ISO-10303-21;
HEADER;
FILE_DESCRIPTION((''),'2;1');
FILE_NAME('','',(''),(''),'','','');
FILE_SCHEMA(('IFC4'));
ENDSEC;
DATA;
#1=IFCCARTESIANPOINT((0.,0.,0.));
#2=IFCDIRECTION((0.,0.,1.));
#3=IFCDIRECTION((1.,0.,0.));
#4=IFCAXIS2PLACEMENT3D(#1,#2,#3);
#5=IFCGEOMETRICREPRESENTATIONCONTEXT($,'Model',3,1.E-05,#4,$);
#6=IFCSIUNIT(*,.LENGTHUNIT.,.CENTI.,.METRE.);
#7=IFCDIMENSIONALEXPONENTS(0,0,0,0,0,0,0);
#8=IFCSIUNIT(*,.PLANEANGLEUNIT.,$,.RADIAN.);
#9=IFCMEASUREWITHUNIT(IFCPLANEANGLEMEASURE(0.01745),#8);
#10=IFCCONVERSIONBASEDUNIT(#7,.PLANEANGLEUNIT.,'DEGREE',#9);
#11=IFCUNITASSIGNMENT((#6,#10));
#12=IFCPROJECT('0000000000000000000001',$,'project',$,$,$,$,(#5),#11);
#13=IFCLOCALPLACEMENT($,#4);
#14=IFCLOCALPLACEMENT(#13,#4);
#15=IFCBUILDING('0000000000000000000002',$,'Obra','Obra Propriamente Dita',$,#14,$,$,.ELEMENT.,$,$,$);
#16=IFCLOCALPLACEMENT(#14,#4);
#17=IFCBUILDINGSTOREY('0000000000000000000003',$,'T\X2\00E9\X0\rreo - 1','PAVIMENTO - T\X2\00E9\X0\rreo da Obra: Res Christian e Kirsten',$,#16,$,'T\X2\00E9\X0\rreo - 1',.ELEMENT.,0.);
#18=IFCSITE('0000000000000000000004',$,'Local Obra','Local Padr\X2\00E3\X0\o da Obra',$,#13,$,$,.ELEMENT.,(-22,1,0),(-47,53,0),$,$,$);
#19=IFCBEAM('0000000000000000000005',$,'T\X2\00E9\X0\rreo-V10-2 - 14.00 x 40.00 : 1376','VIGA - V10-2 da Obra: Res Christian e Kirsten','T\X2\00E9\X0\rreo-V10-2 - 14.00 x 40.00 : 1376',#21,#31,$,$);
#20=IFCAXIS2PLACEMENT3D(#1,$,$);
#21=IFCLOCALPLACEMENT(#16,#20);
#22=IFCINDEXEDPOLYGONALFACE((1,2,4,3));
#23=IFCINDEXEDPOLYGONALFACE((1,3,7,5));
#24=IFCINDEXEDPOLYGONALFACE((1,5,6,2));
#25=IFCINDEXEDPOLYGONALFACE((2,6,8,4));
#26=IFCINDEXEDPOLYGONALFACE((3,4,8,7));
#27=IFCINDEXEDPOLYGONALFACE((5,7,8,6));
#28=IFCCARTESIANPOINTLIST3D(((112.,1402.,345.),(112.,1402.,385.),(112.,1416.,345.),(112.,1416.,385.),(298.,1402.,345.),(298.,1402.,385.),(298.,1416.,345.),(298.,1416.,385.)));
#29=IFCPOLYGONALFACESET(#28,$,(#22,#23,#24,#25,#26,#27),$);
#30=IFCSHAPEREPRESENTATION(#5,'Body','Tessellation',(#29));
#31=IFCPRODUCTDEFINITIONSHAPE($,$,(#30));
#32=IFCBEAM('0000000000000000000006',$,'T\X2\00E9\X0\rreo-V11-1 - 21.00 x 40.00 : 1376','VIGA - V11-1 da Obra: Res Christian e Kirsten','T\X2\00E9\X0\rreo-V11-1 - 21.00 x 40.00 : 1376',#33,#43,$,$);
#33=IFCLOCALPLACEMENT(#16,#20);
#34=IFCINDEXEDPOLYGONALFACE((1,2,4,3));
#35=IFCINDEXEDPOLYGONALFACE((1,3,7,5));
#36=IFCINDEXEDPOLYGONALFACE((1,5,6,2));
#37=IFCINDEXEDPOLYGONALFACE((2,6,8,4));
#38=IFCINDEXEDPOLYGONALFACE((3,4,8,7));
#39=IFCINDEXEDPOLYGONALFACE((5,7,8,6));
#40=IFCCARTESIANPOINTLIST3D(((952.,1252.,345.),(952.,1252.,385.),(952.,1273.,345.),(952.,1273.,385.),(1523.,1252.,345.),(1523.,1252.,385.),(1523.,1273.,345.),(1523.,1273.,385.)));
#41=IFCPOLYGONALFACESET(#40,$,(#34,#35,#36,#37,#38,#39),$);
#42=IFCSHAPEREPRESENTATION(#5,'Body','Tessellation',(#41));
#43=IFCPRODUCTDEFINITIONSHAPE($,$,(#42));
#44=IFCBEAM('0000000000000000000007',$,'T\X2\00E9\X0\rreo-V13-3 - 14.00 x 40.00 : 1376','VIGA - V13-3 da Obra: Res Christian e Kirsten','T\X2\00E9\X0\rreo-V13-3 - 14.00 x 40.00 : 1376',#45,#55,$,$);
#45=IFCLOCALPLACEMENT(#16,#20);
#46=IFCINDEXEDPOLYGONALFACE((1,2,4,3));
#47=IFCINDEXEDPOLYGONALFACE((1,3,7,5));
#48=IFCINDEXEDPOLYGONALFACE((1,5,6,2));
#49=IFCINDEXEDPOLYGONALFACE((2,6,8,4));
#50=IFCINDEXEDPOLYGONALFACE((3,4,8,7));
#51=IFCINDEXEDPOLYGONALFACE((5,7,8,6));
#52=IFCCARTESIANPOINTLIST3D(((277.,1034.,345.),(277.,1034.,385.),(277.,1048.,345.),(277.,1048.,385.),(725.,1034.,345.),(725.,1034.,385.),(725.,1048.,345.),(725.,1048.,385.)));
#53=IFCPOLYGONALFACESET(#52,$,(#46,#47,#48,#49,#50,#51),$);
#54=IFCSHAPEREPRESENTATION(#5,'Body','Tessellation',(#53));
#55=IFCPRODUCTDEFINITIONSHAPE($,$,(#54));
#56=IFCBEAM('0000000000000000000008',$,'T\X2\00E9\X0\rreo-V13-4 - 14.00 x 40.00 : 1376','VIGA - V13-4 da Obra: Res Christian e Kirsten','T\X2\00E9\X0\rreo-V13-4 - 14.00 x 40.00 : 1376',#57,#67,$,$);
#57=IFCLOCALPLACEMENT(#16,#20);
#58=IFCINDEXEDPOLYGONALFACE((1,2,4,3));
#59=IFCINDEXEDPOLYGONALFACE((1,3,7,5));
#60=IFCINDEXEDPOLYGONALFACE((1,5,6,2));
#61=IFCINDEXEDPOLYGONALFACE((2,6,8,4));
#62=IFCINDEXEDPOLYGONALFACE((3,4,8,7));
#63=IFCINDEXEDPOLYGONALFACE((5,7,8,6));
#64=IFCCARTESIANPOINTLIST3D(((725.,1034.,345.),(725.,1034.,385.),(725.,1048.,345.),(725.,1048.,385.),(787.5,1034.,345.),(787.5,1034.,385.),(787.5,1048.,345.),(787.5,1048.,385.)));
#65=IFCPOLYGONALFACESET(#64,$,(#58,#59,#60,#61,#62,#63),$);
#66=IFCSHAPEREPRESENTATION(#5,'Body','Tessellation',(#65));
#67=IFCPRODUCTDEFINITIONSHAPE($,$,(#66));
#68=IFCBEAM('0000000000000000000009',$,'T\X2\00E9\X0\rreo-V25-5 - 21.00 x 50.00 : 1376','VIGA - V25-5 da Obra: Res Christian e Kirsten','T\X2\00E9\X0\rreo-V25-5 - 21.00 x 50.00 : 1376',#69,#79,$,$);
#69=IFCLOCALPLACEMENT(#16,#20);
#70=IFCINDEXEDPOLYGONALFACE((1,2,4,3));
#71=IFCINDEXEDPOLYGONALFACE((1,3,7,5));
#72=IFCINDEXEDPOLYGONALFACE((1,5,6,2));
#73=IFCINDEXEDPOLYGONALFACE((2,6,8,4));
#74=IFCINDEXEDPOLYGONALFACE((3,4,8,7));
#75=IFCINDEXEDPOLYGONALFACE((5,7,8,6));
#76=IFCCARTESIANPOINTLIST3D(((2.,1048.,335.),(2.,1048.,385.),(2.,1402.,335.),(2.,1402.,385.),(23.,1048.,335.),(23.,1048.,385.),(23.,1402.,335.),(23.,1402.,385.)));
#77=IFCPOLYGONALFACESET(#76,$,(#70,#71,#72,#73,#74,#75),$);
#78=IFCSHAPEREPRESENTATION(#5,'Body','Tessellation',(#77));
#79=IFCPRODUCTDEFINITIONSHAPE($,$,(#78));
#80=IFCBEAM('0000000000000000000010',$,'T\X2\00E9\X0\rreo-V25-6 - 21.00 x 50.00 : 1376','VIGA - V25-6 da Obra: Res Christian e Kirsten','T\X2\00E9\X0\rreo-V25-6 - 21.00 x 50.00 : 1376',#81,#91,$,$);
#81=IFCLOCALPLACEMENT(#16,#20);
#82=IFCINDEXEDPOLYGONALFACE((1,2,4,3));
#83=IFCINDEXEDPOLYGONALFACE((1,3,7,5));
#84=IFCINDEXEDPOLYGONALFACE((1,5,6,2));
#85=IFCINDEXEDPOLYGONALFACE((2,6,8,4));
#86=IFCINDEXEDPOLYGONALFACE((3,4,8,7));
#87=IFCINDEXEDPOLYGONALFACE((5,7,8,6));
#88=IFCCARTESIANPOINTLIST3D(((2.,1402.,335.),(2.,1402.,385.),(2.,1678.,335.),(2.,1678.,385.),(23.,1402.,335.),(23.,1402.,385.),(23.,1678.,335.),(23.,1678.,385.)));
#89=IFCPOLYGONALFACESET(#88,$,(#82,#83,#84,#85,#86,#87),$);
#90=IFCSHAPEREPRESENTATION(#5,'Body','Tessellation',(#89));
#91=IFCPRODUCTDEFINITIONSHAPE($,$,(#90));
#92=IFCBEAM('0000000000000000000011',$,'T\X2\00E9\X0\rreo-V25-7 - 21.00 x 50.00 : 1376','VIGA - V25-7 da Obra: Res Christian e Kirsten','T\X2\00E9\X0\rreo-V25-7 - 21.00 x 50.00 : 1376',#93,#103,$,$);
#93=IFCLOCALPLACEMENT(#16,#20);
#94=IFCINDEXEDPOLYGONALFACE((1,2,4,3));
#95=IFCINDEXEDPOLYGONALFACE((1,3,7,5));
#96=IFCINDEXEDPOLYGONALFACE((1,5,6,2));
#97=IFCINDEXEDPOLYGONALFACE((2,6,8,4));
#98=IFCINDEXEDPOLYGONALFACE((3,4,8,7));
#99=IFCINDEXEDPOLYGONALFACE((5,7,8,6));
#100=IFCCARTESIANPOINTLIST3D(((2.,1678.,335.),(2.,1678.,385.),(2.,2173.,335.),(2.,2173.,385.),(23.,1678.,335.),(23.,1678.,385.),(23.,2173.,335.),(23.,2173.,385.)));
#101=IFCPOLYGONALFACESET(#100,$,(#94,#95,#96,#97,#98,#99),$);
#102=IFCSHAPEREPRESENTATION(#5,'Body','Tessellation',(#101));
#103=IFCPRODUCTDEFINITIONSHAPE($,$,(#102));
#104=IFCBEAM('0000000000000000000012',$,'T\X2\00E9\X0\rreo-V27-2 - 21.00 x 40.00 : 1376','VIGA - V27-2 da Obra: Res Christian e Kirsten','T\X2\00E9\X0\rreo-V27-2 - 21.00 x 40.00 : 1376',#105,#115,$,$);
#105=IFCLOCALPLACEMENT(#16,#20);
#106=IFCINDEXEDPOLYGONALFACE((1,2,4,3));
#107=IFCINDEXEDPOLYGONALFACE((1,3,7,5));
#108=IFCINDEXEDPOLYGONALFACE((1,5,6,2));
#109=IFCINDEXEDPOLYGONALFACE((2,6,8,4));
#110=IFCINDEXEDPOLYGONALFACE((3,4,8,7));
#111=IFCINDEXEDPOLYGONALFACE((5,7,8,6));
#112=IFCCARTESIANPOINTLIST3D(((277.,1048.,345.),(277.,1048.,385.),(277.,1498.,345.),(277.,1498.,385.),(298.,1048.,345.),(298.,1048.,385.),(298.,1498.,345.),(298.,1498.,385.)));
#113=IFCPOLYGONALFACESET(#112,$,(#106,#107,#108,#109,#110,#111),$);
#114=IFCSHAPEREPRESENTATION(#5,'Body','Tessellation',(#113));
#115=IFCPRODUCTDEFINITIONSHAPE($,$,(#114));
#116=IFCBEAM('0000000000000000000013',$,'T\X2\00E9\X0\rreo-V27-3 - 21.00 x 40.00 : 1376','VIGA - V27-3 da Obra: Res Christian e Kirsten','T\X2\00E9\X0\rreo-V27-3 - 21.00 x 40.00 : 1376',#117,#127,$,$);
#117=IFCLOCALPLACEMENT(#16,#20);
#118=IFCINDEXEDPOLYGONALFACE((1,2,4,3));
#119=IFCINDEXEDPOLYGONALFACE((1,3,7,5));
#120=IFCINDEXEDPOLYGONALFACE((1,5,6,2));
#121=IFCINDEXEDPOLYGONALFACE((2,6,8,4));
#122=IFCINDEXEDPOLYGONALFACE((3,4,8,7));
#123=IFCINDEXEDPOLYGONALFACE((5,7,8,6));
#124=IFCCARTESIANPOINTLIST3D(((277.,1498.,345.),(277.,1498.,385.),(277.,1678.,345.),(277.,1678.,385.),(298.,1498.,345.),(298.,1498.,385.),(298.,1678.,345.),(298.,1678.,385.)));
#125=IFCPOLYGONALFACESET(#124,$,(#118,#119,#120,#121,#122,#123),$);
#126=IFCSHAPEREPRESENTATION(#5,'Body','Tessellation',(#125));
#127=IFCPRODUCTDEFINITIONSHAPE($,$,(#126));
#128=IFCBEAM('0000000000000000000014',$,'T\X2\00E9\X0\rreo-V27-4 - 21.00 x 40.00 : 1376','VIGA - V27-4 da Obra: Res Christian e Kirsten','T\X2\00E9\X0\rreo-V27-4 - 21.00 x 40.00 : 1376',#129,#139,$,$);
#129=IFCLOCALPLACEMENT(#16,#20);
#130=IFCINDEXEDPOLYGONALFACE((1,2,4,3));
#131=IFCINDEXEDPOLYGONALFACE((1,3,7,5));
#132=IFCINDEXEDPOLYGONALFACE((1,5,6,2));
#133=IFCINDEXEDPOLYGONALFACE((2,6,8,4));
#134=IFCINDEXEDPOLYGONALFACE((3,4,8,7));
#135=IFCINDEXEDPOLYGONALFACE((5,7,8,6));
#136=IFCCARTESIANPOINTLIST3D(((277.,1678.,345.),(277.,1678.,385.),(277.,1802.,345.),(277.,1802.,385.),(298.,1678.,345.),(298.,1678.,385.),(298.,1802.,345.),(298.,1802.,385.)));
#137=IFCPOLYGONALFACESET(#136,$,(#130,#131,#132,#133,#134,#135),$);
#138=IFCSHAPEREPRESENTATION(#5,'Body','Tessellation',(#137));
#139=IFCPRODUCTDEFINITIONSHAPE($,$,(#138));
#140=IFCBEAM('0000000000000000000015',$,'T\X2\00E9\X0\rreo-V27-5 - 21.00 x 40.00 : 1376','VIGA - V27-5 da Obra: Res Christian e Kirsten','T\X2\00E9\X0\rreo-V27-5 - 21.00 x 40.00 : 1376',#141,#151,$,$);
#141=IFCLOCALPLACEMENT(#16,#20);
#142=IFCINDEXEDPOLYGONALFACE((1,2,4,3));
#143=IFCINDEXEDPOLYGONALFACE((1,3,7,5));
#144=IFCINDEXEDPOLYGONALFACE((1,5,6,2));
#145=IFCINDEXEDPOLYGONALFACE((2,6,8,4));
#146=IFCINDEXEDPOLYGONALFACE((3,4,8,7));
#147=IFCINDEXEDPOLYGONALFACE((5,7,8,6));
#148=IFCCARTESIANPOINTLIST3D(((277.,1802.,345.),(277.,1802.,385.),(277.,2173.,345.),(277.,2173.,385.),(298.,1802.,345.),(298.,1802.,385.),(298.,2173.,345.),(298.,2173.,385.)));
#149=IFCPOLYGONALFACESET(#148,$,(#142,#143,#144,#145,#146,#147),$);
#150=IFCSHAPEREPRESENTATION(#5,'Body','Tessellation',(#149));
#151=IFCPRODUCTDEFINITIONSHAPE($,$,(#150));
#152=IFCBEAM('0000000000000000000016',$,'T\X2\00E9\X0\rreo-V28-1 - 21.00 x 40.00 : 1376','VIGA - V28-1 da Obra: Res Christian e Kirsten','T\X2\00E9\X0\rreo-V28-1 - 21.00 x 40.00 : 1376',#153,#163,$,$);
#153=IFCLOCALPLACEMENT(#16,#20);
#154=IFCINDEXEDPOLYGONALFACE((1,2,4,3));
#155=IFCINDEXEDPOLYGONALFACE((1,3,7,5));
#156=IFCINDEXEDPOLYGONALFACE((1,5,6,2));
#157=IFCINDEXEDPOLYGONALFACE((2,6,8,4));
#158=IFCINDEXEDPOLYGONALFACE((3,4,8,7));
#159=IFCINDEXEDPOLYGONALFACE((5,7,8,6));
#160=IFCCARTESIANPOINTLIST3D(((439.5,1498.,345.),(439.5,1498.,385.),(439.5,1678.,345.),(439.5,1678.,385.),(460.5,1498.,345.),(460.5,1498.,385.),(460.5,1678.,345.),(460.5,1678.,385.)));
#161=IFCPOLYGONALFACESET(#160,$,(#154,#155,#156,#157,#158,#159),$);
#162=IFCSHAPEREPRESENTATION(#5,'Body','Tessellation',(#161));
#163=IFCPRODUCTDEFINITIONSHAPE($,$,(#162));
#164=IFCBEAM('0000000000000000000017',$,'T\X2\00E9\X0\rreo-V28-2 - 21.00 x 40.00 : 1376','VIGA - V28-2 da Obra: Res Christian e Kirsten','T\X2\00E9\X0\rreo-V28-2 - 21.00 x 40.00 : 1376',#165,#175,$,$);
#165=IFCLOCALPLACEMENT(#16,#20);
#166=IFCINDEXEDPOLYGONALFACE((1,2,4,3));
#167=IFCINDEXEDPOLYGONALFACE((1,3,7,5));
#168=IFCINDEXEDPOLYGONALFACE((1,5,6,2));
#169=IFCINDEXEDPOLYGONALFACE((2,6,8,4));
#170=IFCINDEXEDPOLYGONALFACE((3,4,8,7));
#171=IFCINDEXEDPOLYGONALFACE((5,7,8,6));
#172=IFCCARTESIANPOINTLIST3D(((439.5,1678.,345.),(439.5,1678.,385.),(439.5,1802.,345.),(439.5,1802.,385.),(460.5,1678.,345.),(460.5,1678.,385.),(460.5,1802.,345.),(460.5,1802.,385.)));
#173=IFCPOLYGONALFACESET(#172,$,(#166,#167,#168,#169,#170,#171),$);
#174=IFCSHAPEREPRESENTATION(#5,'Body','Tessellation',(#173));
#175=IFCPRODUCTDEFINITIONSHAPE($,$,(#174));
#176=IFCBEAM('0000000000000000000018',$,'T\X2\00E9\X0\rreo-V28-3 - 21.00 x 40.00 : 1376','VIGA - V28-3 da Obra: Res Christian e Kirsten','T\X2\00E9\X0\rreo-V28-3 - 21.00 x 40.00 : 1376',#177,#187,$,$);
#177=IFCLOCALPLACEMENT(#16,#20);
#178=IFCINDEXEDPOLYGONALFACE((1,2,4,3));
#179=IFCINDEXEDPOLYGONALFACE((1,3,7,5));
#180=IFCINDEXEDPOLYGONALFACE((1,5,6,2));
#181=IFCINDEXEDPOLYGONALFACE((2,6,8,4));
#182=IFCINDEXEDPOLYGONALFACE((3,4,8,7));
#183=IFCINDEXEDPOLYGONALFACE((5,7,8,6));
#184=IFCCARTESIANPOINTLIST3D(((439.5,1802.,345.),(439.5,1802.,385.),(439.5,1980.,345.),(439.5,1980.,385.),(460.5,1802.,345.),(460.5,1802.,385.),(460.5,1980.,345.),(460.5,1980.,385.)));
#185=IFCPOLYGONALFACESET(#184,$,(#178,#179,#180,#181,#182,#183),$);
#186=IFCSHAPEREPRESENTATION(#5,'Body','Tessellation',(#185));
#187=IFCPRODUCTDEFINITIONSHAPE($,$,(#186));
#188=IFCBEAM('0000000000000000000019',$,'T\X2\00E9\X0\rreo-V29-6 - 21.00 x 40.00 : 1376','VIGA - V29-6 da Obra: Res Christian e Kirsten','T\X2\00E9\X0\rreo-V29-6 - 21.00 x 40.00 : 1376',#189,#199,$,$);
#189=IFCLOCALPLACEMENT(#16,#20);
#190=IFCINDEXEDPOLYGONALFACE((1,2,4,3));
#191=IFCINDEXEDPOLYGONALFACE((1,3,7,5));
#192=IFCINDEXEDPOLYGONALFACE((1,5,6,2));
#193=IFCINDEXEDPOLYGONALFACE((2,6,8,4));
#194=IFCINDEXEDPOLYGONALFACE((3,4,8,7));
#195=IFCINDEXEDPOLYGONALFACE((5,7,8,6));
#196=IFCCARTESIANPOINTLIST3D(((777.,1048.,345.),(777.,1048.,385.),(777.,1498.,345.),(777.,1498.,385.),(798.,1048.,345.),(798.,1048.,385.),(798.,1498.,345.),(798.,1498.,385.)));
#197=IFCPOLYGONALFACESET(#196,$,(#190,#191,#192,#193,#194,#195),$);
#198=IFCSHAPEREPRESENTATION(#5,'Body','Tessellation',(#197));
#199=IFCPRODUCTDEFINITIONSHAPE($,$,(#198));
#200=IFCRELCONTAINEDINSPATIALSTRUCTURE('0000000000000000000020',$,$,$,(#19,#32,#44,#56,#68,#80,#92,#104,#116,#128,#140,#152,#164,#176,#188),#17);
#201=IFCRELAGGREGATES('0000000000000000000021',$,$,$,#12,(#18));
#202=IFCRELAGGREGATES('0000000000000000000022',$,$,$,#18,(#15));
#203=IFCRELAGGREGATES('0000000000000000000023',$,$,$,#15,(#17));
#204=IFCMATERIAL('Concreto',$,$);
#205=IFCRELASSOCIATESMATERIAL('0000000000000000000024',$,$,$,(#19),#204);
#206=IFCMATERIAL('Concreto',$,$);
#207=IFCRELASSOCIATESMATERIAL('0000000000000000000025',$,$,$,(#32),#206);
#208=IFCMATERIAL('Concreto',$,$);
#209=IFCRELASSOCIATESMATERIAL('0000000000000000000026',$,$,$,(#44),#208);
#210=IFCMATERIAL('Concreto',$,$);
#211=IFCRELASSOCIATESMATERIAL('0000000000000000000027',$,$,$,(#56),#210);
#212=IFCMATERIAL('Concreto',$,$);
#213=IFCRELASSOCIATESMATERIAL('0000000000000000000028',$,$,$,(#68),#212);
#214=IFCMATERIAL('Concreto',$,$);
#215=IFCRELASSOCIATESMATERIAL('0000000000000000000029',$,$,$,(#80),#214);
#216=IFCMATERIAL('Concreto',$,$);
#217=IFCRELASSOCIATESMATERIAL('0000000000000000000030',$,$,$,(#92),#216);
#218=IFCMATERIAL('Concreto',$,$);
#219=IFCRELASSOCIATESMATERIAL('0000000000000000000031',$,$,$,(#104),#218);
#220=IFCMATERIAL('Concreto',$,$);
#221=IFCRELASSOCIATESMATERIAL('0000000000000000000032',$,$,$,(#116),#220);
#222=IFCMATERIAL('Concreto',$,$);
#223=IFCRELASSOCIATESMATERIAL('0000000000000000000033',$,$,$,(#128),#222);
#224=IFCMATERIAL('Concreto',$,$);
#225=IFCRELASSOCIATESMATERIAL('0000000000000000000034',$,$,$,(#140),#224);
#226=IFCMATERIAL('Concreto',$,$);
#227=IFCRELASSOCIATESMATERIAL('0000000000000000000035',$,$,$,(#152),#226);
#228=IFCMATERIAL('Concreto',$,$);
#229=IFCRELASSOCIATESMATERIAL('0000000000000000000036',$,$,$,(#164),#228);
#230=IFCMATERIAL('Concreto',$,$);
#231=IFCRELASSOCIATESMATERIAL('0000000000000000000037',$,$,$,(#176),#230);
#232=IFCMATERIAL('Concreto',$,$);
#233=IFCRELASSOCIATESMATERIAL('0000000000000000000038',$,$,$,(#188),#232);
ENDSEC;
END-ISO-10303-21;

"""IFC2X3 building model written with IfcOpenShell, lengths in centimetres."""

from ifc_helpers import new_model, entity, si_unit, converted_unit, frame, origin_with_axes, place, context, project, spatial, polyline, outline, extrude, material, element, save


model = new_model("IFC2X3")

# Units and contexts
model_context = context("Model", 3, precision=1e-05, world=origin_with_axes())
ifc_project = project(units=[si_unit("LENGTHUNIT", "METRE", prefix="CENTI"), converted_unit("PLANEANGLEUNIT", "DEGREE", entity("IfcPlaneAngleMeasure", 0.01745), si_unit("PLANEANGLEUNIT", "RADIAN"), dimensions=[0, 0, 0, 0, 0, 0, 0])], contexts=[model_context])

# Site, building, storey
site_placement = place(None, origin_with_axes())
site = spatial("IfcSite", under=ifc_project, at=site_placement, Name="Local Obra", Description="Local Padrão da Obra", CompositionType="ELEMENT", RefLatitude=(-22, 1, 0), RefLongitude=(-47, 53, 0))
building_placement = place(site_placement, origin_with_axes())
building = spatial("IfcBuilding", under=site, at=building_placement, Name="Obra", Description="Obra Propriamente Dita", CompositionType="ELEMENT")
storey_placement = place(building_placement, origin_with_axes())
storey = spatial("IfcBuildingStorey", under=building, at=storey_placement, Name="Térreo - 1", Description="PAVIMENTO - Térreo da Obra: Res Christian e Kirsten", LongName="Térreo - 1", CompositionType="ELEMENT", Elevation=0.0)

# Beams
ifc_material_1 = material(Name="Concreto")
beam_1_placement = place(storey_placement, frame((112.0, 1402.0, 385.0), z_axis=(1.0, 0.0, 0.0), x_axis=(0.0, -1.0, 0.0)))
element("IfcBeam", 1, at=beam_1_placement, inside=storey, material=ifc_material_1, Name="Térreo-V10-2 - 14.00 x 40.00 : 1376", Description="VIGA - V10-2 da Obra: Res Christian e Kirsten", ObjectType="Térreo-V10-2 - 14.00 x 40.00 : 1376", context=model_context, shape_type="SweptSolid", body=[
    extrude(outline(polyline([(-14.0, 0.0), (0.0, 0.0), (0.0, 40.0), (-14.0, 40.0), (-14.0, 0.0)])), origin_with_axes(), (0.0, 0.0, 1.0), 186.0),
])
ifc_material_2 = material(Name="Concreto")
beam_2_placement = place(storey_placement, frame((952.0, 1252.0, 385.0), z_axis=(1.0, 0.0, 0.0), x_axis=(0.0, -1.0, 0.0)))
element("IfcBeam", 2, at=beam_2_placement, inside=storey, material=ifc_material_2, Name="Térreo-V11-1 - 21.00 x 40.00 : 1376", Description="VIGA - V11-1 da Obra: Res Christian e Kirsten", ObjectType="Térreo-V11-1 - 21.00 x 40.00 : 1376", context=model_context, shape_type="SweptSolid", body=[
    extrude(outline(polyline([(-21.0, 0.0), (0.0, 0.0), (0.0, 40.0), (-21.0, 40.0), (-21.0, 0.0)])), origin_with_axes(), (0.0, 0.0, 1.0), 571.0),
])
ifc_material_3 = material(Name="Concreto")
beam_3_placement = place(storey_placement, frame((277.0, 1048.0, 385.0), z_axis=(1.0, 0.0, 0.0), x_axis=(0.0, -1.0, 0.0)))
element("IfcBeam", 3, at=beam_3_placement, inside=storey, material=ifc_material_3, Name="Térreo-V13-3 - 14.00 x 40.00 : 1376", Description="VIGA - V13-3 da Obra: Res Christian e Kirsten", ObjectType="Térreo-V13-3 - 14.00 x 40.00 : 1376", context=model_context, shape_type="SweptSolid", body=[
    extrude(outline(polyline([(0.0, 0.0), (14.0, 0.0), (14.0, 40.0), (0.0, 40.0), (0.0, 0.0)])), origin_with_axes(), (0.0, 0.0, 1.0), 448.0),
])
ifc_material_4 = material(Name="Concreto")
beam_4_placement = place(storey_placement, frame((725.0, 1048.0, 385.0), z_axis=(1.0, 0.0, 0.0), x_axis=(0.0, -1.0, 0.0)))
element("IfcBeam", 4, at=beam_4_placement, inside=storey, material=ifc_material_4, Name="Térreo-V13-4 - 14.00 x 40.00 : 1376", Description="VIGA - V13-4 da Obra: Res Christian e Kirsten", ObjectType="Térreo-V13-4 - 14.00 x 40.00 : 1376", context=model_context, shape_type="SweptSolid", body=[
    extrude(outline(polyline([(0.0, 0.0), (14.0, 0.0), (14.0, 40.0), (0.0, 40.0), (0.0, 0.0)])), origin_with_axes(), (0.0, 0.0, 1.0), 62.5),
])
ifc_material_5 = material(Name="Concreto")
beam_5_placement = place(storey_placement, frame((2.0, 1048.0, 385.0), z_axis=(0.0, 1.0, 0.0), x_axis=(1.0, 0.0, 0.0)))
element("IfcBeam", 5, at=beam_5_placement, inside=storey, material=ifc_material_5, Name="Térreo-V25-5 - 21.00 x 50.00 : 1376", Description="VIGA - V25-5 da Obra: Res Christian e Kirsten", ObjectType="Térreo-V25-5 - 21.00 x 50.00 : 1376", context=model_context, shape_type="SweptSolid", body=[
    extrude(outline(polyline([(0.0, 0.0), (21.0, 0.0), (21.0, 50.0), (0.0, 50.0), (0.0, 0.0)])), origin_with_axes(), (0.0, 0.0, 1.0), 354.0),
])
ifc_material_6 = material(Name="Concreto")
beam_6_placement = place(storey_placement, frame((2.0, 1402.0, 385.0), z_axis=(0.0, 1.0, 0.0), x_axis=(1.0, 0.0, 0.0)))
element("IfcBeam", 6, at=beam_6_placement, inside=storey, material=ifc_material_6, Name="Térreo-V25-6 - 21.00 x 50.00 : 1376", Description="VIGA - V25-6 da Obra: Res Christian e Kirsten", ObjectType="Térreo-V25-6 - 21.00 x 50.00 : 1376", context=model_context, shape_type="SweptSolid", body=[
    extrude(outline(polyline([(0.0, 0.0), (21.0, 0.0), (21.0, 50.0), (0.0, 50.0), (0.0, 0.0)])), origin_with_axes(), (0.0, 0.0, 1.0), 276.0),
])
ifc_material_7 = material(Name="Concreto")
beam_7_placement = place(storey_placement, frame((2.0, 1678.0, 385.0), z_axis=(0.0, 1.0, 0.0), x_axis=(1.0, 0.0, 0.0)))
element("IfcBeam", 7, at=beam_7_placement, inside=storey, material=ifc_material_7, Name="Térreo-V25-7 - 21.00 x 50.00 : 1376", Description="VIGA - V25-7 da Obra: Res Christian e Kirsten", ObjectType="Térreo-V25-7 - 21.00 x 50.00 : 1376", context=model_context, shape_type="SweptSolid", body=[
    extrude(outline(polyline([(0.0, 0.0), (21.0, 0.0), (21.0, 50.0), (0.0, 50.0), (0.0, 0.0)])), origin_with_axes(), (0.0, 0.0, 1.0), 495.0),
])
ifc_material_8 = material(Name="Concreto")
beam_8_placement = place(storey_placement, frame((277.0, 1048.0, 385.0), z_axis=(0.0, 1.0, 0.0), x_axis=(1.0, 0.0, 0.0)))
element("IfcBeam", 8, at=beam_8_placement, inside=storey, material=ifc_material_8, Name="Térreo-V27-2 - 21.00 x 40.00 : 1376", Description="VIGA - V27-2 da Obra: Res Christian e Kirsten", ObjectType="Térreo-V27-2 - 21.00 x 40.00 : 1376", context=model_context, shape_type="SweptSolid", body=[
    extrude(outline(polyline([(0.0, 0.0), (21.0, 0.0), (21.0, 40.0), (0.0, 40.0), (0.0, 0.0)])), origin_with_axes(), (0.0, 0.0, 1.0), 450.0),
])
ifc_material_9 = material(Name="Concreto")
beam_9_placement = place(storey_placement, frame((277.0, 1498.0, 385.0), z_axis=(0.0, 1.0, 0.0), x_axis=(1.0, 0.0, 0.0)))
element("IfcBeam", 9, at=beam_9_placement, inside=storey, material=ifc_material_9, Name="Térreo-V27-3 - 21.00 x 40.00 : 1376", Description="VIGA - V27-3 da Obra: Res Christian e Kirsten", ObjectType="Térreo-V27-3 - 21.00 x 40.00 : 1376", context=model_context, shape_type="SweptSolid", body=[
    extrude(outline(polyline([(0.0, 0.0), (21.0, 0.0), (21.0, 40.0), (0.0, 40.0), (0.0, 0.0)])), origin_with_axes(), (0.0, 0.0, 1.0), 180.0),
])
ifc_material_10 = material(Name="Concreto")
beam_10_placement = place(storey_placement, frame((277.0, 1678.0, 385.0), z_axis=(-0.000001, 1.0, 0.0), x_axis=(1.0, 0.000001, 0.0)))
element("IfcBeam", 10, at=beam_10_placement, inside=storey, material=ifc_material_10, Name="Térreo-V27-4 - 21.00 x 40.00 : 1376", Description="VIGA - V27-4 da Obra: Res Christian e Kirsten", ObjectType="Térreo-V27-4 - 21.00 x 40.00 : 1376", context=model_context, shape_type="SweptSolid", body=[
    extrude(outline(polyline([(0.0, 0.0), (21.0, 0.0), (21.0, 40.0), (0.0, 40.0), (0.0, 0.0)])), origin_with_axes(), (0.0, 0.0, 1.0), 124.0),
])
ifc_material_11 = material(Name="Concreto")
beam_11_placement = place(storey_placement, frame((277.0, 1802.0, 385.0), z_axis=(0.0, 1.0, 0.0), x_axis=(1.0, 0.0, 0.0)))
element("IfcBeam", 11, at=beam_11_placement, inside=storey, material=ifc_material_11, Name="Térreo-V27-5 - 21.00 x 40.00 : 1376", Description="VIGA - V27-5 da Obra: Res Christian e Kirsten", ObjectType="Térreo-V27-5 - 21.00 x 40.00 : 1376", context=model_context, shape_type="SweptSolid", body=[
    extrude(outline(polyline([(0.0, 0.0), (21.0, 0.0), (21.0, 40.0), (0.0, 40.0), (0.0, 0.0)])), origin_with_axes(), (0.0, 0.0, 1.0), 371.0),
])
ifc_material_12 = material(Name="Concreto")
beam_12_placement = place(storey_placement, frame((450.0, 1498.0, 385.0), z_axis=(0.0, 1.0, 0.0), x_axis=(1.0, 0.0, 0.0)))
element("IfcBeam", 12, at=beam_12_placement, inside=storey, material=ifc_material_12, Name="Térreo-V28-1 - 21.00 x 40.00 : 1376", Description="VIGA - V28-1 da Obra: Res Christian e Kirsten", ObjectType="Térreo-V28-1 - 21.00 x 40.00 : 1376", context=model_context, shape_type="SweptSolid", body=[
    extrude(outline(polyline([(-10.5, 0.0), (10.5, 0.0), (10.5, 40.0), (-10.5, 40.0), (-10.5, 0.0)])), origin_with_axes(), (0.0, 0.0, 1.0), 180.0),
])
ifc_material_13 = material(Name="Concreto")
beam_13_placement = place(storey_placement, frame((450.0, 1678.0, 385.0), z_axis=(0.0, 1.0, 0.0), x_axis=(1.0, 0.0, 0.0)))
element("IfcBeam", 13, at=beam_13_placement, inside=storey, material=ifc_material_13, Name="Térreo-V28-2 - 21.00 x 40.00 : 1376", Description="VIGA - V28-2 da Obra: Res Christian e Kirsten", ObjectType="Térreo-V28-2 - 21.00 x 40.00 : 1376", context=model_context, shape_type="SweptSolid", body=[
    extrude(outline(polyline([(-10.5, 0.0), (10.5, 0.0), (10.5, 40.0), (-10.5, 40.0), (-10.5, 0.0)])), origin_with_axes(), (0.0, 0.0, 1.0), 124.0),
])
ifc_material_14 = material(Name="Concreto")
beam_14_placement = place(storey_placement, frame((450.0, 1802.0, 385.0), z_axis=(0.0, 1.0, 0.0), x_axis=(1.0, 0.0, 0.0)))
element("IfcBeam", 14, at=beam_14_placement, inside=storey, material=ifc_material_14, Name="Térreo-V28-3 - 21.00 x 40.00 : 1376", Description="VIGA - V28-3 da Obra: Res Christian e Kirsten", ObjectType="Térreo-V28-3 - 21.00 x 40.00 : 1376", context=model_context, shape_type="SweptSolid", body=[
    extrude(outline(polyline([(-10.5, 0.0), (10.5, 0.0), (10.5, 40.0), (-10.5, 40.0), (-10.5, 0.0)])), origin_with_axes(), (0.0, 0.0, 1.0), 178.0),
])
ifc_material_15 = material(Name="Concreto")
beam_15_placement = place(storey_placement, frame((787.5, 1048.0, 385.0), z_axis=(0.0, 1.0, 0.0), x_axis=(1.0, 0.0, 0.0)))
element("IfcBeam", 15, at=beam_15_placement, inside=storey, material=ifc_material_15, Name="Térreo-V29-6 - 21.00 x 40.00 : 1376", Description="VIGA - V29-6 da Obra: Res Christian e Kirsten", ObjectType="Térreo-V29-6 - 21.00 x 40.00 : 1376", context=model_context, shape_type="SweptSolid", body=[
    extrude(outline(polyline([(-10.5, 0.0), (10.5, 0.0), (10.5, 40.0), (-10.5, 40.0), (-10.5, 0.0)])), origin_with_axes(), (0.0, 0.0, 1.0), 450.0),
])

save(model, "model.ifc")
